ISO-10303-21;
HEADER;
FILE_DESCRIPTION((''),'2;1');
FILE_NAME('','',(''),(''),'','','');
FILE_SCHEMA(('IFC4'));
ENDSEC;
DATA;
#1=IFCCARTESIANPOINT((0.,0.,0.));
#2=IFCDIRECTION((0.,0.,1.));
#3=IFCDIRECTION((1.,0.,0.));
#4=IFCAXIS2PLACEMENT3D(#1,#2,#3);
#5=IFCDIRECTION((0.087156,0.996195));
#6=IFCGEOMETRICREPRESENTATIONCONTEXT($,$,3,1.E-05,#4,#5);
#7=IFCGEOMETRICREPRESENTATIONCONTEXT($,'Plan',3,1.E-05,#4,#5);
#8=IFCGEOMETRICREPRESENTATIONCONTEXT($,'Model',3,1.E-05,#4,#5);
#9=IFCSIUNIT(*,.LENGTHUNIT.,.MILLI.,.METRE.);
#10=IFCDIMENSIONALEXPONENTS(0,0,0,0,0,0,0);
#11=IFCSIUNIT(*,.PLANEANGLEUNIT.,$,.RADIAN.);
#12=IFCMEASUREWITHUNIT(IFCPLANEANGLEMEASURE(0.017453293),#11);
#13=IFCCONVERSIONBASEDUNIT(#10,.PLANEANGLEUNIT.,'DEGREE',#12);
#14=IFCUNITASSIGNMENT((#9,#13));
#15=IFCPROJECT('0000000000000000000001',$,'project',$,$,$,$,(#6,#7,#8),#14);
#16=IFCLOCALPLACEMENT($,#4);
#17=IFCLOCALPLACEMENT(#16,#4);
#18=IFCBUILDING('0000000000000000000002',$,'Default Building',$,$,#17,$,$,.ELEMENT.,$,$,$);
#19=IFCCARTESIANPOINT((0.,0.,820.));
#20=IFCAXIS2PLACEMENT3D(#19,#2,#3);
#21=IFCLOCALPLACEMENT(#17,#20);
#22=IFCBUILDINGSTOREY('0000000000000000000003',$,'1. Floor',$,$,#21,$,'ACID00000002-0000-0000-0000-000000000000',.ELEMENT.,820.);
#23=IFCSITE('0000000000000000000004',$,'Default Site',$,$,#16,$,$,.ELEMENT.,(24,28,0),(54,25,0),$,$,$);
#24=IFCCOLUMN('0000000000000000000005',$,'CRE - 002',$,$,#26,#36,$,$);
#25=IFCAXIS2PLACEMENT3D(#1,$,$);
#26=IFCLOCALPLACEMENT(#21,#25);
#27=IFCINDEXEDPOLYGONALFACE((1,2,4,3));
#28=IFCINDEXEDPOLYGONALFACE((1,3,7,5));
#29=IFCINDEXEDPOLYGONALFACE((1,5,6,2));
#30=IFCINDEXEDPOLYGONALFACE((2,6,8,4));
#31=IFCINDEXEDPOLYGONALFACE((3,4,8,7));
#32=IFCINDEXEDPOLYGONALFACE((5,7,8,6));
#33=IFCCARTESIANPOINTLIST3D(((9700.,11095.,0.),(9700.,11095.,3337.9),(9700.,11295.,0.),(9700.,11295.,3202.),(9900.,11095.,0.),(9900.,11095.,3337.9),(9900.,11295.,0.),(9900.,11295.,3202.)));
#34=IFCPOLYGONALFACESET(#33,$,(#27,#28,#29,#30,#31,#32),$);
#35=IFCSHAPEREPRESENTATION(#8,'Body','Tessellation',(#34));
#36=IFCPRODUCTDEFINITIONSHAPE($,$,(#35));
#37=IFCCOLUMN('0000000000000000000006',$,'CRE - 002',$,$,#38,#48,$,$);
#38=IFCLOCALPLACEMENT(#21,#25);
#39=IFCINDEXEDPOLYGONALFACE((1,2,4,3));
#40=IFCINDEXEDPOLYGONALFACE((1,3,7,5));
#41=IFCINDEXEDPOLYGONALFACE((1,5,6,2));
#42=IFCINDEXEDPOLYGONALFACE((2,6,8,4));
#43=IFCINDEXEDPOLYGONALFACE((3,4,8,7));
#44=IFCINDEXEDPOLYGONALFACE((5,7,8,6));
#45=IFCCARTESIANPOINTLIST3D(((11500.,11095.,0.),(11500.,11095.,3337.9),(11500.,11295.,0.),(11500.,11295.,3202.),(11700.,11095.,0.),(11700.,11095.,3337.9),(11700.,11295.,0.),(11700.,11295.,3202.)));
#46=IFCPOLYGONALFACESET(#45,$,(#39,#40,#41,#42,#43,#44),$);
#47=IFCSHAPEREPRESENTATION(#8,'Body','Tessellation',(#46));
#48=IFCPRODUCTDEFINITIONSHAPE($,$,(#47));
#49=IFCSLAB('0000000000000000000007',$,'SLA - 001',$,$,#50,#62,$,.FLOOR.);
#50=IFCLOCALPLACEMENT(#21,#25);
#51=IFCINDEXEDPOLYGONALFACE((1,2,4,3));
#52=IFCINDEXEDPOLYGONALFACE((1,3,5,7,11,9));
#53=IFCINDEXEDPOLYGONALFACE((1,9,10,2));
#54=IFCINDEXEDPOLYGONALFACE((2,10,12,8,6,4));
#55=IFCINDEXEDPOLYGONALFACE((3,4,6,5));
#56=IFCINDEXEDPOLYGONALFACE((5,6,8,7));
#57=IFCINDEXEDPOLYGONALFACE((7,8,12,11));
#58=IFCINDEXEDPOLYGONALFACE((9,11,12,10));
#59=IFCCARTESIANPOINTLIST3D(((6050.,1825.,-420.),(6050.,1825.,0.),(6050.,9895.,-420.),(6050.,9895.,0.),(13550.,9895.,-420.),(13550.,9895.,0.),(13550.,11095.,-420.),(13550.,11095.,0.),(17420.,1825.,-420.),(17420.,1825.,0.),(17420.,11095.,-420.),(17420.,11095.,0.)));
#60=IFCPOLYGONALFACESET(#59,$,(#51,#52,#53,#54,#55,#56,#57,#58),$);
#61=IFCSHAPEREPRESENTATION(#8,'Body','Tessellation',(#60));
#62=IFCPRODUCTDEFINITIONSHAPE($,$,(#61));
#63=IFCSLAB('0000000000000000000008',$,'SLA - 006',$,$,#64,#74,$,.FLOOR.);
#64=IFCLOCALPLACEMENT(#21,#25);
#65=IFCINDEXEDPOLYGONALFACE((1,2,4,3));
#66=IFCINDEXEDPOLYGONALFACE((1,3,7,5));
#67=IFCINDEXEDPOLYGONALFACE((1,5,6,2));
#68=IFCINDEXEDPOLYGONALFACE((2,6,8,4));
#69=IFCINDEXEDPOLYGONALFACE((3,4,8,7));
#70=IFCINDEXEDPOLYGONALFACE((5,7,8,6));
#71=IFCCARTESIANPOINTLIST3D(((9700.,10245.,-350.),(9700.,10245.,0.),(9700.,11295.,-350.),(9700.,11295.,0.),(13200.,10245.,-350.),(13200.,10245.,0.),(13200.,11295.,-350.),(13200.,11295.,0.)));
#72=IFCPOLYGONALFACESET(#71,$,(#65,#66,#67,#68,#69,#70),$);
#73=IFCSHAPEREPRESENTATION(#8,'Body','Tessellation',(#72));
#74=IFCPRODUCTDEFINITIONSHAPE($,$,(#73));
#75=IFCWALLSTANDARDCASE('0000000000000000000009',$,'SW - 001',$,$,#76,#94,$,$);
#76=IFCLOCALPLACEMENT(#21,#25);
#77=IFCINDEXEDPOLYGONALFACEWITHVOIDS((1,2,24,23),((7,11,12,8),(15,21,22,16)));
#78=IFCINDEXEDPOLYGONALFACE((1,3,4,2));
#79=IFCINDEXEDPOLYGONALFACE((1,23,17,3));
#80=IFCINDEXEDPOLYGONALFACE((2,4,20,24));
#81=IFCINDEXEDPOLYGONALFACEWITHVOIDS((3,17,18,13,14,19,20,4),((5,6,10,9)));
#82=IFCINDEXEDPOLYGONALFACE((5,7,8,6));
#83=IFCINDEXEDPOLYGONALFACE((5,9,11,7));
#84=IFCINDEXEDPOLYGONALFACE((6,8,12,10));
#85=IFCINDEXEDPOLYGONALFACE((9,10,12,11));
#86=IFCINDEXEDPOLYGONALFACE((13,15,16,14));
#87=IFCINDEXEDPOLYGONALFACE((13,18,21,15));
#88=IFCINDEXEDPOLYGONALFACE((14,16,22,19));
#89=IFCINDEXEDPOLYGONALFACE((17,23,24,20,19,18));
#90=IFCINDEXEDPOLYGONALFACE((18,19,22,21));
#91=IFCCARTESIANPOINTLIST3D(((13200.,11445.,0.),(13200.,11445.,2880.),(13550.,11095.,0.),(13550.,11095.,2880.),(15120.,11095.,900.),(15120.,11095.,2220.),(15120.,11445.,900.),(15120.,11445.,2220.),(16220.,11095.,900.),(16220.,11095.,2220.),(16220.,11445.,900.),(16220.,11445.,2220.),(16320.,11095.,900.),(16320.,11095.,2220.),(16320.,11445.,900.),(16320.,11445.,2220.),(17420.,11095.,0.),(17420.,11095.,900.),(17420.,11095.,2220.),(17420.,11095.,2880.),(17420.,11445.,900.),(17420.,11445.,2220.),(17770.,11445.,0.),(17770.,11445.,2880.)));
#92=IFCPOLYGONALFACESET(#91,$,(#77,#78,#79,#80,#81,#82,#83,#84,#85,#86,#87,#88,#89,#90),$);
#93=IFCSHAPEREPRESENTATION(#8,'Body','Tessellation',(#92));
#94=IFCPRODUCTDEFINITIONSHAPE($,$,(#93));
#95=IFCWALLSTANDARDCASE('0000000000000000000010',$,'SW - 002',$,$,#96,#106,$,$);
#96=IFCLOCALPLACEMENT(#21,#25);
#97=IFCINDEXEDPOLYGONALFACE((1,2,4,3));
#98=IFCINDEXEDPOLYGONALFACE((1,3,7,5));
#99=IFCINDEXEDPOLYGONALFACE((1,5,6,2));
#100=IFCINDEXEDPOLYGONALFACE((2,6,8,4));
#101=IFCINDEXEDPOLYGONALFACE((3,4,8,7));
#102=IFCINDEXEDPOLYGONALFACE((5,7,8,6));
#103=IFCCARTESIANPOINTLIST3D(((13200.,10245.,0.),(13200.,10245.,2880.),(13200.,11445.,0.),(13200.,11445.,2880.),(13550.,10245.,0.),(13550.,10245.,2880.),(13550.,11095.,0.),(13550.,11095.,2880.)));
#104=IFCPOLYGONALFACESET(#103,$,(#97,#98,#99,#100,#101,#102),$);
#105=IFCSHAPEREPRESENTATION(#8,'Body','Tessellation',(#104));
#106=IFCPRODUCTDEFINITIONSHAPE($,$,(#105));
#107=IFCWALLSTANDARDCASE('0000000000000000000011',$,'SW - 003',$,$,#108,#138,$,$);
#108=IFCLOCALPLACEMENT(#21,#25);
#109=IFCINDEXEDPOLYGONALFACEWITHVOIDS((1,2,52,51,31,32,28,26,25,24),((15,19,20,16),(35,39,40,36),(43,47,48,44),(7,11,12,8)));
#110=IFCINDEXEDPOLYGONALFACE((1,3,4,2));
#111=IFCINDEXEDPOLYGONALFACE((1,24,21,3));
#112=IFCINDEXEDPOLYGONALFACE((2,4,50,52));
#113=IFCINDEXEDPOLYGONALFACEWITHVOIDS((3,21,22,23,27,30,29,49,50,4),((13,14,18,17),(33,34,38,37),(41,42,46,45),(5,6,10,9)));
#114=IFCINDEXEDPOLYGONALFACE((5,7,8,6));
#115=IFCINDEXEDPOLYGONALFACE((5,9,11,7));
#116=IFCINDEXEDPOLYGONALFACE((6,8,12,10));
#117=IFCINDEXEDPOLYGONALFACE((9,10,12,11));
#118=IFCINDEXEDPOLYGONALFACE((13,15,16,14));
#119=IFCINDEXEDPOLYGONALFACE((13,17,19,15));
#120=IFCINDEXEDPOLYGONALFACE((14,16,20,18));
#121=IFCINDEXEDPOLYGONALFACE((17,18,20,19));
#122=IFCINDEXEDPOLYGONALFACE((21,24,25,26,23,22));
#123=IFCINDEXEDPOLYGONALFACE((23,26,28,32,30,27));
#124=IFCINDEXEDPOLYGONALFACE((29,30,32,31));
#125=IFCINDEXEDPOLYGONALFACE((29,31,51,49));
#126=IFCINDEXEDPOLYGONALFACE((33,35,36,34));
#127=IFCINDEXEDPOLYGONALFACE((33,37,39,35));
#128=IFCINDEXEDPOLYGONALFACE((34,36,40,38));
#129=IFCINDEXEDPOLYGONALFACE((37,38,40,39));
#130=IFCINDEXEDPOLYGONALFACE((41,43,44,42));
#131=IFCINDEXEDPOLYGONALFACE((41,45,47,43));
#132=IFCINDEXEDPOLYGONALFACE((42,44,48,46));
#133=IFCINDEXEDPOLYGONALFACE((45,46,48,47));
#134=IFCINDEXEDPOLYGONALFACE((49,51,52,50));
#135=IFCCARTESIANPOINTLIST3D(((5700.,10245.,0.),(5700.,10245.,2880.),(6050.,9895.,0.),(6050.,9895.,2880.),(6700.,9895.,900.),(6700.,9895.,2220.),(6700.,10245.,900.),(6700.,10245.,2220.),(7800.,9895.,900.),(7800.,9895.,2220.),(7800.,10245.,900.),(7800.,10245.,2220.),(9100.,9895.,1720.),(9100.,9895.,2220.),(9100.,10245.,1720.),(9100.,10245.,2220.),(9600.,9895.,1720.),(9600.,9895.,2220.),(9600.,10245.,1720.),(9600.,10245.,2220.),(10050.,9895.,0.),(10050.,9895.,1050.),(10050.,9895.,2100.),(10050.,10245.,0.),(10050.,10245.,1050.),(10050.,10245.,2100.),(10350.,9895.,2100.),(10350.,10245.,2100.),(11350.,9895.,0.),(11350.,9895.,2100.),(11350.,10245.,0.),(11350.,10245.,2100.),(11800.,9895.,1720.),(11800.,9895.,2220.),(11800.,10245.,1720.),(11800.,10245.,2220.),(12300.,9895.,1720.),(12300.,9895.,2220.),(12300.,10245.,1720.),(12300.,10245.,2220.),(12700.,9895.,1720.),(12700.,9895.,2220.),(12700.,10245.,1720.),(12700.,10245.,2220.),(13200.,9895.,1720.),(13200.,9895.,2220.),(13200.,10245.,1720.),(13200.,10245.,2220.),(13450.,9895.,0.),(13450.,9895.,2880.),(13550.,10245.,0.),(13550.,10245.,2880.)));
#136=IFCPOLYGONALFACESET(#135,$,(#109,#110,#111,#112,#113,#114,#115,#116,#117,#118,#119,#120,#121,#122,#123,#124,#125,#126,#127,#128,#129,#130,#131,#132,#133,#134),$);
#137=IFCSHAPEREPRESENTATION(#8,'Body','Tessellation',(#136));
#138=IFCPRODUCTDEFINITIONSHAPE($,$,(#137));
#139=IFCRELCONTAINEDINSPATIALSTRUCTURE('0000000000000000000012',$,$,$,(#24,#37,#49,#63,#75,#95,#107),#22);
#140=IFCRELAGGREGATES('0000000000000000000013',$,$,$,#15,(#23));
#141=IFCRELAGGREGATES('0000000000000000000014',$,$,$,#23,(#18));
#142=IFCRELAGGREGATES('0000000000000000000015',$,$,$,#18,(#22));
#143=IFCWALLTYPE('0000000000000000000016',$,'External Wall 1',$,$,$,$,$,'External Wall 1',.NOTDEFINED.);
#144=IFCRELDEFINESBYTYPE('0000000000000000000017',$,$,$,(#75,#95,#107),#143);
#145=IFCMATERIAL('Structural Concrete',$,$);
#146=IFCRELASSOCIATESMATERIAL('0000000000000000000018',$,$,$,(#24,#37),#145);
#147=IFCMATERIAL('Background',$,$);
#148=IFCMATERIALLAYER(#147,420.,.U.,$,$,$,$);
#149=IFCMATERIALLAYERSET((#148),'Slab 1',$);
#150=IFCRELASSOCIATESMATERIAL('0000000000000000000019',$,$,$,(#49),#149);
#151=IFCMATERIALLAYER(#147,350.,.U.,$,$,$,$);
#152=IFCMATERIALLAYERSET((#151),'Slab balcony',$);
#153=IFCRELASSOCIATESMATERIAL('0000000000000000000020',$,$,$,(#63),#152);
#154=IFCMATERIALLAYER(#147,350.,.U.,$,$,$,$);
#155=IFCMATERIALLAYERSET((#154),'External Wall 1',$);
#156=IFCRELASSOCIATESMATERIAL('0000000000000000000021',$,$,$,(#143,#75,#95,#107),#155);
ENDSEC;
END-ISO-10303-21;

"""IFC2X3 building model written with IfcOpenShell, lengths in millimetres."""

from ifc_helpers import new_model, entity, si_unit, converted_unit, direction, frame, frame_2d, origin_with_axes, origin_2d_with_axis, place, context, project, spatial, polyline, rectangle, outline, extrude, clip, halfspace, material, layer, layer_set, layer_usage, type_object, element, save


model = new_model("IFC2X3")

# Units and contexts
context_of_model = context(None, 3, precision=1e-05, world=origin_with_axes(), true_north=direction((0.087156, 0.996195)))
plan_context = context("Plan", 3, precision=1e-05, world=origin_with_axes(), true_north=direction((0.087156, 0.996195)))
model_context = context("Model", 3, precision=1e-05, world=origin_with_axes(), true_north=direction((0.087156, 0.996195)))
ifc_project = project(units=[si_unit("LENGTHUNIT", "METRE", prefix="MILLI"), converted_unit("PLANEANGLEUNIT", "DEGREE", entity("IfcPlaneAngleMeasure", 0.017453293), si_unit("PLANEANGLEUNIT", "RADIAN"), dimensions=[0, 0, 0, 0, 0, 0, 0])], contexts=[context_of_model, plan_context, model_context])

# Site, building, storey
site_placement = place(None, origin_with_axes())
site = spatial("IfcSite", under=ifc_project, at=site_placement, Name="Default Site", CompositionType="ELEMENT", RefLatitude=(24, 28, 0), RefLongitude=(54, 25, 0))
building_placement = place(site_placement, origin_with_axes())
building = spatial("IfcBuilding", under=site, at=building_placement, Name="Default Building", CompositionType="ELEMENT")
storey_placement = place(building_placement, frame((0.0, 0.0, 820.0), z_axis=(0.0, 0.0, 1.0), x_axis=(1.0, 0.0, 0.0)))
storey = spatial("IfcBuildingStorey", under=building, at=storey_placement, Name="1. Floor", LongName="ACID00000002-0000-0000-0000-000000000000", CompositionType="ELEMENT", Elevation=820.0)

# Columns
ifc_material_1 = material(Name="Structural Concrete")
for number, where, z_axis, x_axis, name in (
    (1, (9800.0, 11195.0, 0.0), (0.0, 0.0, 1.0), (-1.0, 0.0, 0.0), "CRE - 002"),
    (2, (11600.0, 11195.0, 0.0), (0.0, 0.0, 1.0), (-1.0, 0.0, 0.0), "CRE - 002"),
):
    element("IfcColumn", number, at=place(storey_placement, frame(where, z_axis=z_axis, x_axis=x_axis)), inside=storey, material=ifc_material_1, Name=name, context=model_context, shape_type="Clipping", body=[
        clip(extrude(rectangle(XDim=200.0, YDim=200.0, at=origin_2d_with_axis()), origin_with_axes(), (0.0, 0.0, 1.0), 3337.9), halfspace(frame((0.0, -1520.2, 2236.6), z_axis=(0.0, -0.562142, 0.827041), x_axis=(0.0, 0.827041, 0.562142)), False)),
    ])

# Slabs
ifc_material_2 = material(Name="Background")
ifc_layer_1 = layer(ifc_material_2, 420.0, ventilated="UNKNOWN")
ifc_layer_set_1 = layer_set([ifc_layer_1], Name="Slab 1")
ifc_layer_usage_1 = layer_usage(ifc_layer_set_1, "AXIS3", "NEGATIVE", 420.0)
slab_1_placement = place(storey_placement, frame((17420.0, 11095.0, -420.0), z_axis=(0.0, 0.0, 1.0), x_axis=(-1.0, 0.0, 0.0)))
element("IfcSlab", 3, at=slab_1_placement, inside=storey, material=ifc_layer_usage_1, Name="SLA - 001", PredefinedType="FLOOR", context=model_context, shape_type="SweptSolid", body=[
    extrude(outline(polyline([(0.0, 0.0), (3870.0, 0.0), (3870.0, 1200.0), (11370.0, 1200.0), (11370.0, 9270.0), (0.0, 9270.0), (0.0, 0.0)])), origin_with_axes(), (0.0, 0.0, 1.0), 420.0),
])
ifc_layer_2 = layer(ifc_material_2, 350.0, ventilated="UNKNOWN")
ifc_layer_set_2 = layer_set([ifc_layer_2], Name="Slab balcony")
ifc_layer_usage_2 = layer_usage(ifc_layer_set_2, "AXIS3", "NEGATIVE", 350.0)
slab_2_placement = place(storey_placement, frame((13200.0, 10245.0, -350.0), z_axis=(0.0, 0.0, 1.0), x_axis=(0.0, 1.0, 0.0)))
element("IfcSlab", 4, at=slab_2_placement, inside=storey, material=ifc_layer_usage_2, Name="SLA - 006", PredefinedType="FLOOR", context=model_context, shape_type="SweptSolid", body=[
    extrude(outline(polyline([(0.0, 0.0), (1050.0, 0.0), (1050.0, 3500.0), (0.0, 3500.0), (0.0, 0.0)])), origin_with_axes(), (0.0, 0.0, 1.0), 350.0),
])

# Wall, openings
ifc_layer_3 = layer(ifc_material_2, 350.0, ventilated="UNKNOWN")
ifc_layer_set_3 = layer_set([ifc_layer_3], Name="External Wall 1")
ifc_layer_usage_3 = layer_usage(ifc_layer_set_3, "AXIS2", "POSITIVE", 0.0)
wall_type_1 = type_object("IfcWallType", Name="External Wall 1", ElementType="External Wall 1", PredefinedType="NOTDEFINED", material=ifc_layer_set_3)
wall_1_placement = place(storey_placement, frame((17770.0, 11445.0, 0.0), z_axis=(0.0, 0.0, 1.0), x_axis=(-1.0, 0.0, 0.0)))
wall_1 = element("IfcWallStandardCase", 5, at=wall_1_placement, inside=storey, type_object=wall_type_1, material=ifc_layer_usage_3, Name="SW - 001", context=model_context, shape_type="SweptSolid", body=[
    extrude(outline(polyline([(0.0, 0.0), (4570.0, 0.0), (4220.0, 350.0), (350.0, 350.0), (0.0, 0.0)])), origin_with_axes(), (0.0, 0.0, 1.0), 2880.0),
])
opening_1_placement = place(wall_1_placement, frame((900.0, 0.0, 900.0), z_axis=(0.0, 0.0, 1.0), x_axis=(1.0, 0.0, 0.0)))
element("IfcOpeningElement", 6, at=opening_1_placement, cuts=wall_1, ObjectType="Opening", context=model_context, shape_type="SweptSolid", body=[
    extrude(rectangle(XDim=1100.0, YDim=1320.0, at=frame_2d((0.0, 660.0), x_axis=(1.0, 0.0))), frame((0.0, 0.0, 0.0), z_axis=(0.0, 1.0, 0.0), x_axis=(-1.0, 0.0, 0.0)), (0.0, 0.0, 1.0), 350.0),
])
opening_2_placement = place(wall_1_placement, frame((2100.0, 0.0, 900.0), z_axis=(0.0, 0.0, 1.0), x_axis=(1.0, 0.0, 0.0)))
element("IfcOpeningElement", 7, at=opening_2_placement, cuts=wall_1, ObjectType="Opening", context=model_context, shape_type="SweptSolid", body=[
    extrude(rectangle(XDim=1100.0, YDim=1320.0, at=frame_2d((0.0, 660.0), x_axis=(-1.0, 0.0))), frame((0.0, 0.0, 0.0), z_axis=(0.0, 1.0, 0.0), x_axis=(-1.0, 0.0, 0.0)), (0.0, 0.0, 1.0), 350.0),
])

# Wall
ifc_layer_usage_4 = layer_usage(ifc_layer_set_3, "AXIS2", "POSITIVE", 0.0)
wall_2_placement = place(storey_placement, frame((13200.0, 11445.0, 0.0), z_axis=(0.0, 0.0, 1.0), x_axis=(0.0, -1.0, 0.0)))
element("IfcWallStandardCase", 8, at=wall_2_placement, inside=storey, type_object=wall_type_1, material=ifc_layer_usage_4, Name="SW - 002", context=model_context, shape_type="SweptSolid", body=[
    extrude(outline(polyline([(0.0, 0.0), (1200.0, 0.0), (1200.0, 350.0), (350.0, 350.0), (0.0, 0.0)])), origin_with_axes(), (0.0, 0.0, 1.0), 2880.0),
])

# Wall, openings
ifc_layer_usage_5 = layer_usage(ifc_layer_set_3, "AXIS2", "POSITIVE", 0.0)
wall_3_placement = place(storey_placement, frame((13550.0, 10245.0, 0.0), z_axis=(0.0, 0.0, 1.0), x_axis=(-1.0, 0.0, 0.0)))
wall_3 = element("IfcWallStandardCase", 9, at=wall_3_placement, inside=storey, type_object=wall_type_1, material=ifc_layer_usage_5, Name="SW - 003", context=model_context, shape_type="SweptSolid", body=[
    extrude(outline(polyline([(0.0, 0.0), (7850.0, 0.0), (7500.0, 350.0), (100.0, 350.0), (0.0, 0.0)])), origin_with_axes(), (0.0, 0.0, 1.0), 2880.0),
])
opening_3_placement = place(wall_3_placement, frame((2700.0, 0.0, 0.0), z_axis=(0.0, 0.0, 1.0), x_axis=(1.0, 0.0, 0.0)))
element("IfcOpeningElement", 10, at=opening_3_placement, cuts=wall_3, ObjectType="Opening", context=model_context, shape_type="SweptSolid", body=[
    extrude(outline(polyline([(-500.0, 0.0), (500.0, 0.0), (500.0, 2100.0), (-500.0, 2100.0), (-500.0, 0.0)])), frame((0.0, 0.0, 0.0), z_axis=(0.0, 1.0, 0.0), x_axis=(-1.0, 0.0, 0.0)), (0.0, 0.0, 1.0), 350.0),
])
opening_4_placement = place(wall_3_placement, frame((6300.0, 0.0, 900.0), z_axis=(0.0, 0.0, 1.0), x_axis=(1.0, 0.0, 0.0)))
element("IfcOpeningElement", 11, at=opening_4_placement, cuts=wall_3, ObjectType="Opening", context=model_context, shape_type="SweptSolid", body=[
    extrude(rectangle(XDim=1100.0, YDim=1320.0, at=frame_2d((0.0, 660.0), x_axis=(-1.0, 0.0))), frame((0.0, 0.0, 0.0), z_axis=(0.0, 1.0, 0.0), x_axis=(-1.0, 0.0, 0.0)), (0.0, 0.0, 1.0), 350.0),
])
opening_5_placement = place(wall_3_placement, frame((600.0, 0.0, 1720.0), z_axis=(0.0, 0.0, 1.0), x_axis=(1.0, 0.0, 0.0)))
element("IfcOpeningElement", 12, at=opening_5_placement, cuts=wall_3, ObjectType="Opening", context=model_context, shape_type="SweptSolid", body=[
    extrude(rectangle(XDim=500.0, YDim=500.0, at=frame_2d((0.0, 250.0), x_axis=(-1.0, 0.0))), frame((0.0, 0.0, 0.0), z_axis=(0.0, 1.0, 0.0), x_axis=(-1.0, 0.0, 0.0)), (0.0, 0.0, 1.0), 350.0),
])
opening_6_placement = place(wall_3_placement, frame((1500.0, 0.0, 1720.0), z_axis=(0.0, 0.0, 1.0), x_axis=(1.0, 0.0, 0.0)))
element("IfcOpeningElement", 13, at=opening_6_placement, cuts=wall_3, ObjectType="Opening", context=model_context, shape_type="SweptSolid", body=[
    extrude(rectangle(XDim=500.0, YDim=500.0, at=frame_2d((0.0, 250.0), x_axis=(-1.0, 0.0))), frame((0.0, 0.0, 0.0), z_axis=(0.0, 1.0, 0.0), x_axis=(-1.0, 0.0, 0.0)), (0.0, 0.0, 1.0), 350.0),
])
opening_7_placement = place(wall_3_placement, frame((4200.0, 0.0, 1720.0), z_axis=(0.0, 0.0, 1.0), x_axis=(1.0, 0.0, 0.0)))
element("IfcOpeningElement", 14, at=opening_7_placement, cuts=wall_3, ObjectType="Opening", context=model_context, shape_type="SweptSolid", body=[
    extrude(rectangle(XDim=500.0, YDim=500.0, at=frame_2d((0.0, 250.0), x_axis=(-1.0, 0.0))), frame((0.0, 0.0, 0.0), z_axis=(0.0, 1.0, 0.0), x_axis=(-1.0, 0.0, 0.0)), (0.0, 0.0, 1.0), 350.0),
])
opening_8_placement = place(wall_3_placement, frame((3350.0, 0.0, 0.0), z_axis=(0.0, 0.0, 1.0), x_axis=(1.0, 0.0, 0.0)))
element("IfcOpeningElement", 15, at=opening_8_placement, cuts=wall_3, ObjectType="Opening", context=model_context, shape_type="SweptSolid", body=[
    extrude(outline(polyline([(-150.0, 0.0), (150.0, 0.0), (150.0, 1050.0), (-150.0, 1050.0), (-150.0, 0.0)])), frame((0.0, 0.0, 0.0), z_axis=(0.0, 1.0, 0.0), x_axis=(-1.0, 0.0, 0.0)), (0.0, 0.0, 1.0), 350.0),
])
opening_9_placement = place(wall_3_placement, frame((3350.0, 0.0, 1050.0), z_axis=(0.0, 0.0, 1.0), x_axis=(1.0, 0.0, 0.0)))
element("IfcOpeningElement", 16, at=opening_9_placement, cuts=wall_3, ObjectType="Opening", context=model_context, shape_type="SweptSolid", body=[
    extrude(outline(polyline([(-150.0, 0.0), (150.0, 0.0), (150.0, 1050.0), (-150.0, 1050.0), (-150.0, 0.0)])), frame((0.0, 0.0, 0.0), z_axis=(0.0, 1.0, 0.0), x_axis=(-1.0, 0.0, 0.0)), (0.0, 0.0, 1.0), 350.0),
])

save(model, "model.ifc")
